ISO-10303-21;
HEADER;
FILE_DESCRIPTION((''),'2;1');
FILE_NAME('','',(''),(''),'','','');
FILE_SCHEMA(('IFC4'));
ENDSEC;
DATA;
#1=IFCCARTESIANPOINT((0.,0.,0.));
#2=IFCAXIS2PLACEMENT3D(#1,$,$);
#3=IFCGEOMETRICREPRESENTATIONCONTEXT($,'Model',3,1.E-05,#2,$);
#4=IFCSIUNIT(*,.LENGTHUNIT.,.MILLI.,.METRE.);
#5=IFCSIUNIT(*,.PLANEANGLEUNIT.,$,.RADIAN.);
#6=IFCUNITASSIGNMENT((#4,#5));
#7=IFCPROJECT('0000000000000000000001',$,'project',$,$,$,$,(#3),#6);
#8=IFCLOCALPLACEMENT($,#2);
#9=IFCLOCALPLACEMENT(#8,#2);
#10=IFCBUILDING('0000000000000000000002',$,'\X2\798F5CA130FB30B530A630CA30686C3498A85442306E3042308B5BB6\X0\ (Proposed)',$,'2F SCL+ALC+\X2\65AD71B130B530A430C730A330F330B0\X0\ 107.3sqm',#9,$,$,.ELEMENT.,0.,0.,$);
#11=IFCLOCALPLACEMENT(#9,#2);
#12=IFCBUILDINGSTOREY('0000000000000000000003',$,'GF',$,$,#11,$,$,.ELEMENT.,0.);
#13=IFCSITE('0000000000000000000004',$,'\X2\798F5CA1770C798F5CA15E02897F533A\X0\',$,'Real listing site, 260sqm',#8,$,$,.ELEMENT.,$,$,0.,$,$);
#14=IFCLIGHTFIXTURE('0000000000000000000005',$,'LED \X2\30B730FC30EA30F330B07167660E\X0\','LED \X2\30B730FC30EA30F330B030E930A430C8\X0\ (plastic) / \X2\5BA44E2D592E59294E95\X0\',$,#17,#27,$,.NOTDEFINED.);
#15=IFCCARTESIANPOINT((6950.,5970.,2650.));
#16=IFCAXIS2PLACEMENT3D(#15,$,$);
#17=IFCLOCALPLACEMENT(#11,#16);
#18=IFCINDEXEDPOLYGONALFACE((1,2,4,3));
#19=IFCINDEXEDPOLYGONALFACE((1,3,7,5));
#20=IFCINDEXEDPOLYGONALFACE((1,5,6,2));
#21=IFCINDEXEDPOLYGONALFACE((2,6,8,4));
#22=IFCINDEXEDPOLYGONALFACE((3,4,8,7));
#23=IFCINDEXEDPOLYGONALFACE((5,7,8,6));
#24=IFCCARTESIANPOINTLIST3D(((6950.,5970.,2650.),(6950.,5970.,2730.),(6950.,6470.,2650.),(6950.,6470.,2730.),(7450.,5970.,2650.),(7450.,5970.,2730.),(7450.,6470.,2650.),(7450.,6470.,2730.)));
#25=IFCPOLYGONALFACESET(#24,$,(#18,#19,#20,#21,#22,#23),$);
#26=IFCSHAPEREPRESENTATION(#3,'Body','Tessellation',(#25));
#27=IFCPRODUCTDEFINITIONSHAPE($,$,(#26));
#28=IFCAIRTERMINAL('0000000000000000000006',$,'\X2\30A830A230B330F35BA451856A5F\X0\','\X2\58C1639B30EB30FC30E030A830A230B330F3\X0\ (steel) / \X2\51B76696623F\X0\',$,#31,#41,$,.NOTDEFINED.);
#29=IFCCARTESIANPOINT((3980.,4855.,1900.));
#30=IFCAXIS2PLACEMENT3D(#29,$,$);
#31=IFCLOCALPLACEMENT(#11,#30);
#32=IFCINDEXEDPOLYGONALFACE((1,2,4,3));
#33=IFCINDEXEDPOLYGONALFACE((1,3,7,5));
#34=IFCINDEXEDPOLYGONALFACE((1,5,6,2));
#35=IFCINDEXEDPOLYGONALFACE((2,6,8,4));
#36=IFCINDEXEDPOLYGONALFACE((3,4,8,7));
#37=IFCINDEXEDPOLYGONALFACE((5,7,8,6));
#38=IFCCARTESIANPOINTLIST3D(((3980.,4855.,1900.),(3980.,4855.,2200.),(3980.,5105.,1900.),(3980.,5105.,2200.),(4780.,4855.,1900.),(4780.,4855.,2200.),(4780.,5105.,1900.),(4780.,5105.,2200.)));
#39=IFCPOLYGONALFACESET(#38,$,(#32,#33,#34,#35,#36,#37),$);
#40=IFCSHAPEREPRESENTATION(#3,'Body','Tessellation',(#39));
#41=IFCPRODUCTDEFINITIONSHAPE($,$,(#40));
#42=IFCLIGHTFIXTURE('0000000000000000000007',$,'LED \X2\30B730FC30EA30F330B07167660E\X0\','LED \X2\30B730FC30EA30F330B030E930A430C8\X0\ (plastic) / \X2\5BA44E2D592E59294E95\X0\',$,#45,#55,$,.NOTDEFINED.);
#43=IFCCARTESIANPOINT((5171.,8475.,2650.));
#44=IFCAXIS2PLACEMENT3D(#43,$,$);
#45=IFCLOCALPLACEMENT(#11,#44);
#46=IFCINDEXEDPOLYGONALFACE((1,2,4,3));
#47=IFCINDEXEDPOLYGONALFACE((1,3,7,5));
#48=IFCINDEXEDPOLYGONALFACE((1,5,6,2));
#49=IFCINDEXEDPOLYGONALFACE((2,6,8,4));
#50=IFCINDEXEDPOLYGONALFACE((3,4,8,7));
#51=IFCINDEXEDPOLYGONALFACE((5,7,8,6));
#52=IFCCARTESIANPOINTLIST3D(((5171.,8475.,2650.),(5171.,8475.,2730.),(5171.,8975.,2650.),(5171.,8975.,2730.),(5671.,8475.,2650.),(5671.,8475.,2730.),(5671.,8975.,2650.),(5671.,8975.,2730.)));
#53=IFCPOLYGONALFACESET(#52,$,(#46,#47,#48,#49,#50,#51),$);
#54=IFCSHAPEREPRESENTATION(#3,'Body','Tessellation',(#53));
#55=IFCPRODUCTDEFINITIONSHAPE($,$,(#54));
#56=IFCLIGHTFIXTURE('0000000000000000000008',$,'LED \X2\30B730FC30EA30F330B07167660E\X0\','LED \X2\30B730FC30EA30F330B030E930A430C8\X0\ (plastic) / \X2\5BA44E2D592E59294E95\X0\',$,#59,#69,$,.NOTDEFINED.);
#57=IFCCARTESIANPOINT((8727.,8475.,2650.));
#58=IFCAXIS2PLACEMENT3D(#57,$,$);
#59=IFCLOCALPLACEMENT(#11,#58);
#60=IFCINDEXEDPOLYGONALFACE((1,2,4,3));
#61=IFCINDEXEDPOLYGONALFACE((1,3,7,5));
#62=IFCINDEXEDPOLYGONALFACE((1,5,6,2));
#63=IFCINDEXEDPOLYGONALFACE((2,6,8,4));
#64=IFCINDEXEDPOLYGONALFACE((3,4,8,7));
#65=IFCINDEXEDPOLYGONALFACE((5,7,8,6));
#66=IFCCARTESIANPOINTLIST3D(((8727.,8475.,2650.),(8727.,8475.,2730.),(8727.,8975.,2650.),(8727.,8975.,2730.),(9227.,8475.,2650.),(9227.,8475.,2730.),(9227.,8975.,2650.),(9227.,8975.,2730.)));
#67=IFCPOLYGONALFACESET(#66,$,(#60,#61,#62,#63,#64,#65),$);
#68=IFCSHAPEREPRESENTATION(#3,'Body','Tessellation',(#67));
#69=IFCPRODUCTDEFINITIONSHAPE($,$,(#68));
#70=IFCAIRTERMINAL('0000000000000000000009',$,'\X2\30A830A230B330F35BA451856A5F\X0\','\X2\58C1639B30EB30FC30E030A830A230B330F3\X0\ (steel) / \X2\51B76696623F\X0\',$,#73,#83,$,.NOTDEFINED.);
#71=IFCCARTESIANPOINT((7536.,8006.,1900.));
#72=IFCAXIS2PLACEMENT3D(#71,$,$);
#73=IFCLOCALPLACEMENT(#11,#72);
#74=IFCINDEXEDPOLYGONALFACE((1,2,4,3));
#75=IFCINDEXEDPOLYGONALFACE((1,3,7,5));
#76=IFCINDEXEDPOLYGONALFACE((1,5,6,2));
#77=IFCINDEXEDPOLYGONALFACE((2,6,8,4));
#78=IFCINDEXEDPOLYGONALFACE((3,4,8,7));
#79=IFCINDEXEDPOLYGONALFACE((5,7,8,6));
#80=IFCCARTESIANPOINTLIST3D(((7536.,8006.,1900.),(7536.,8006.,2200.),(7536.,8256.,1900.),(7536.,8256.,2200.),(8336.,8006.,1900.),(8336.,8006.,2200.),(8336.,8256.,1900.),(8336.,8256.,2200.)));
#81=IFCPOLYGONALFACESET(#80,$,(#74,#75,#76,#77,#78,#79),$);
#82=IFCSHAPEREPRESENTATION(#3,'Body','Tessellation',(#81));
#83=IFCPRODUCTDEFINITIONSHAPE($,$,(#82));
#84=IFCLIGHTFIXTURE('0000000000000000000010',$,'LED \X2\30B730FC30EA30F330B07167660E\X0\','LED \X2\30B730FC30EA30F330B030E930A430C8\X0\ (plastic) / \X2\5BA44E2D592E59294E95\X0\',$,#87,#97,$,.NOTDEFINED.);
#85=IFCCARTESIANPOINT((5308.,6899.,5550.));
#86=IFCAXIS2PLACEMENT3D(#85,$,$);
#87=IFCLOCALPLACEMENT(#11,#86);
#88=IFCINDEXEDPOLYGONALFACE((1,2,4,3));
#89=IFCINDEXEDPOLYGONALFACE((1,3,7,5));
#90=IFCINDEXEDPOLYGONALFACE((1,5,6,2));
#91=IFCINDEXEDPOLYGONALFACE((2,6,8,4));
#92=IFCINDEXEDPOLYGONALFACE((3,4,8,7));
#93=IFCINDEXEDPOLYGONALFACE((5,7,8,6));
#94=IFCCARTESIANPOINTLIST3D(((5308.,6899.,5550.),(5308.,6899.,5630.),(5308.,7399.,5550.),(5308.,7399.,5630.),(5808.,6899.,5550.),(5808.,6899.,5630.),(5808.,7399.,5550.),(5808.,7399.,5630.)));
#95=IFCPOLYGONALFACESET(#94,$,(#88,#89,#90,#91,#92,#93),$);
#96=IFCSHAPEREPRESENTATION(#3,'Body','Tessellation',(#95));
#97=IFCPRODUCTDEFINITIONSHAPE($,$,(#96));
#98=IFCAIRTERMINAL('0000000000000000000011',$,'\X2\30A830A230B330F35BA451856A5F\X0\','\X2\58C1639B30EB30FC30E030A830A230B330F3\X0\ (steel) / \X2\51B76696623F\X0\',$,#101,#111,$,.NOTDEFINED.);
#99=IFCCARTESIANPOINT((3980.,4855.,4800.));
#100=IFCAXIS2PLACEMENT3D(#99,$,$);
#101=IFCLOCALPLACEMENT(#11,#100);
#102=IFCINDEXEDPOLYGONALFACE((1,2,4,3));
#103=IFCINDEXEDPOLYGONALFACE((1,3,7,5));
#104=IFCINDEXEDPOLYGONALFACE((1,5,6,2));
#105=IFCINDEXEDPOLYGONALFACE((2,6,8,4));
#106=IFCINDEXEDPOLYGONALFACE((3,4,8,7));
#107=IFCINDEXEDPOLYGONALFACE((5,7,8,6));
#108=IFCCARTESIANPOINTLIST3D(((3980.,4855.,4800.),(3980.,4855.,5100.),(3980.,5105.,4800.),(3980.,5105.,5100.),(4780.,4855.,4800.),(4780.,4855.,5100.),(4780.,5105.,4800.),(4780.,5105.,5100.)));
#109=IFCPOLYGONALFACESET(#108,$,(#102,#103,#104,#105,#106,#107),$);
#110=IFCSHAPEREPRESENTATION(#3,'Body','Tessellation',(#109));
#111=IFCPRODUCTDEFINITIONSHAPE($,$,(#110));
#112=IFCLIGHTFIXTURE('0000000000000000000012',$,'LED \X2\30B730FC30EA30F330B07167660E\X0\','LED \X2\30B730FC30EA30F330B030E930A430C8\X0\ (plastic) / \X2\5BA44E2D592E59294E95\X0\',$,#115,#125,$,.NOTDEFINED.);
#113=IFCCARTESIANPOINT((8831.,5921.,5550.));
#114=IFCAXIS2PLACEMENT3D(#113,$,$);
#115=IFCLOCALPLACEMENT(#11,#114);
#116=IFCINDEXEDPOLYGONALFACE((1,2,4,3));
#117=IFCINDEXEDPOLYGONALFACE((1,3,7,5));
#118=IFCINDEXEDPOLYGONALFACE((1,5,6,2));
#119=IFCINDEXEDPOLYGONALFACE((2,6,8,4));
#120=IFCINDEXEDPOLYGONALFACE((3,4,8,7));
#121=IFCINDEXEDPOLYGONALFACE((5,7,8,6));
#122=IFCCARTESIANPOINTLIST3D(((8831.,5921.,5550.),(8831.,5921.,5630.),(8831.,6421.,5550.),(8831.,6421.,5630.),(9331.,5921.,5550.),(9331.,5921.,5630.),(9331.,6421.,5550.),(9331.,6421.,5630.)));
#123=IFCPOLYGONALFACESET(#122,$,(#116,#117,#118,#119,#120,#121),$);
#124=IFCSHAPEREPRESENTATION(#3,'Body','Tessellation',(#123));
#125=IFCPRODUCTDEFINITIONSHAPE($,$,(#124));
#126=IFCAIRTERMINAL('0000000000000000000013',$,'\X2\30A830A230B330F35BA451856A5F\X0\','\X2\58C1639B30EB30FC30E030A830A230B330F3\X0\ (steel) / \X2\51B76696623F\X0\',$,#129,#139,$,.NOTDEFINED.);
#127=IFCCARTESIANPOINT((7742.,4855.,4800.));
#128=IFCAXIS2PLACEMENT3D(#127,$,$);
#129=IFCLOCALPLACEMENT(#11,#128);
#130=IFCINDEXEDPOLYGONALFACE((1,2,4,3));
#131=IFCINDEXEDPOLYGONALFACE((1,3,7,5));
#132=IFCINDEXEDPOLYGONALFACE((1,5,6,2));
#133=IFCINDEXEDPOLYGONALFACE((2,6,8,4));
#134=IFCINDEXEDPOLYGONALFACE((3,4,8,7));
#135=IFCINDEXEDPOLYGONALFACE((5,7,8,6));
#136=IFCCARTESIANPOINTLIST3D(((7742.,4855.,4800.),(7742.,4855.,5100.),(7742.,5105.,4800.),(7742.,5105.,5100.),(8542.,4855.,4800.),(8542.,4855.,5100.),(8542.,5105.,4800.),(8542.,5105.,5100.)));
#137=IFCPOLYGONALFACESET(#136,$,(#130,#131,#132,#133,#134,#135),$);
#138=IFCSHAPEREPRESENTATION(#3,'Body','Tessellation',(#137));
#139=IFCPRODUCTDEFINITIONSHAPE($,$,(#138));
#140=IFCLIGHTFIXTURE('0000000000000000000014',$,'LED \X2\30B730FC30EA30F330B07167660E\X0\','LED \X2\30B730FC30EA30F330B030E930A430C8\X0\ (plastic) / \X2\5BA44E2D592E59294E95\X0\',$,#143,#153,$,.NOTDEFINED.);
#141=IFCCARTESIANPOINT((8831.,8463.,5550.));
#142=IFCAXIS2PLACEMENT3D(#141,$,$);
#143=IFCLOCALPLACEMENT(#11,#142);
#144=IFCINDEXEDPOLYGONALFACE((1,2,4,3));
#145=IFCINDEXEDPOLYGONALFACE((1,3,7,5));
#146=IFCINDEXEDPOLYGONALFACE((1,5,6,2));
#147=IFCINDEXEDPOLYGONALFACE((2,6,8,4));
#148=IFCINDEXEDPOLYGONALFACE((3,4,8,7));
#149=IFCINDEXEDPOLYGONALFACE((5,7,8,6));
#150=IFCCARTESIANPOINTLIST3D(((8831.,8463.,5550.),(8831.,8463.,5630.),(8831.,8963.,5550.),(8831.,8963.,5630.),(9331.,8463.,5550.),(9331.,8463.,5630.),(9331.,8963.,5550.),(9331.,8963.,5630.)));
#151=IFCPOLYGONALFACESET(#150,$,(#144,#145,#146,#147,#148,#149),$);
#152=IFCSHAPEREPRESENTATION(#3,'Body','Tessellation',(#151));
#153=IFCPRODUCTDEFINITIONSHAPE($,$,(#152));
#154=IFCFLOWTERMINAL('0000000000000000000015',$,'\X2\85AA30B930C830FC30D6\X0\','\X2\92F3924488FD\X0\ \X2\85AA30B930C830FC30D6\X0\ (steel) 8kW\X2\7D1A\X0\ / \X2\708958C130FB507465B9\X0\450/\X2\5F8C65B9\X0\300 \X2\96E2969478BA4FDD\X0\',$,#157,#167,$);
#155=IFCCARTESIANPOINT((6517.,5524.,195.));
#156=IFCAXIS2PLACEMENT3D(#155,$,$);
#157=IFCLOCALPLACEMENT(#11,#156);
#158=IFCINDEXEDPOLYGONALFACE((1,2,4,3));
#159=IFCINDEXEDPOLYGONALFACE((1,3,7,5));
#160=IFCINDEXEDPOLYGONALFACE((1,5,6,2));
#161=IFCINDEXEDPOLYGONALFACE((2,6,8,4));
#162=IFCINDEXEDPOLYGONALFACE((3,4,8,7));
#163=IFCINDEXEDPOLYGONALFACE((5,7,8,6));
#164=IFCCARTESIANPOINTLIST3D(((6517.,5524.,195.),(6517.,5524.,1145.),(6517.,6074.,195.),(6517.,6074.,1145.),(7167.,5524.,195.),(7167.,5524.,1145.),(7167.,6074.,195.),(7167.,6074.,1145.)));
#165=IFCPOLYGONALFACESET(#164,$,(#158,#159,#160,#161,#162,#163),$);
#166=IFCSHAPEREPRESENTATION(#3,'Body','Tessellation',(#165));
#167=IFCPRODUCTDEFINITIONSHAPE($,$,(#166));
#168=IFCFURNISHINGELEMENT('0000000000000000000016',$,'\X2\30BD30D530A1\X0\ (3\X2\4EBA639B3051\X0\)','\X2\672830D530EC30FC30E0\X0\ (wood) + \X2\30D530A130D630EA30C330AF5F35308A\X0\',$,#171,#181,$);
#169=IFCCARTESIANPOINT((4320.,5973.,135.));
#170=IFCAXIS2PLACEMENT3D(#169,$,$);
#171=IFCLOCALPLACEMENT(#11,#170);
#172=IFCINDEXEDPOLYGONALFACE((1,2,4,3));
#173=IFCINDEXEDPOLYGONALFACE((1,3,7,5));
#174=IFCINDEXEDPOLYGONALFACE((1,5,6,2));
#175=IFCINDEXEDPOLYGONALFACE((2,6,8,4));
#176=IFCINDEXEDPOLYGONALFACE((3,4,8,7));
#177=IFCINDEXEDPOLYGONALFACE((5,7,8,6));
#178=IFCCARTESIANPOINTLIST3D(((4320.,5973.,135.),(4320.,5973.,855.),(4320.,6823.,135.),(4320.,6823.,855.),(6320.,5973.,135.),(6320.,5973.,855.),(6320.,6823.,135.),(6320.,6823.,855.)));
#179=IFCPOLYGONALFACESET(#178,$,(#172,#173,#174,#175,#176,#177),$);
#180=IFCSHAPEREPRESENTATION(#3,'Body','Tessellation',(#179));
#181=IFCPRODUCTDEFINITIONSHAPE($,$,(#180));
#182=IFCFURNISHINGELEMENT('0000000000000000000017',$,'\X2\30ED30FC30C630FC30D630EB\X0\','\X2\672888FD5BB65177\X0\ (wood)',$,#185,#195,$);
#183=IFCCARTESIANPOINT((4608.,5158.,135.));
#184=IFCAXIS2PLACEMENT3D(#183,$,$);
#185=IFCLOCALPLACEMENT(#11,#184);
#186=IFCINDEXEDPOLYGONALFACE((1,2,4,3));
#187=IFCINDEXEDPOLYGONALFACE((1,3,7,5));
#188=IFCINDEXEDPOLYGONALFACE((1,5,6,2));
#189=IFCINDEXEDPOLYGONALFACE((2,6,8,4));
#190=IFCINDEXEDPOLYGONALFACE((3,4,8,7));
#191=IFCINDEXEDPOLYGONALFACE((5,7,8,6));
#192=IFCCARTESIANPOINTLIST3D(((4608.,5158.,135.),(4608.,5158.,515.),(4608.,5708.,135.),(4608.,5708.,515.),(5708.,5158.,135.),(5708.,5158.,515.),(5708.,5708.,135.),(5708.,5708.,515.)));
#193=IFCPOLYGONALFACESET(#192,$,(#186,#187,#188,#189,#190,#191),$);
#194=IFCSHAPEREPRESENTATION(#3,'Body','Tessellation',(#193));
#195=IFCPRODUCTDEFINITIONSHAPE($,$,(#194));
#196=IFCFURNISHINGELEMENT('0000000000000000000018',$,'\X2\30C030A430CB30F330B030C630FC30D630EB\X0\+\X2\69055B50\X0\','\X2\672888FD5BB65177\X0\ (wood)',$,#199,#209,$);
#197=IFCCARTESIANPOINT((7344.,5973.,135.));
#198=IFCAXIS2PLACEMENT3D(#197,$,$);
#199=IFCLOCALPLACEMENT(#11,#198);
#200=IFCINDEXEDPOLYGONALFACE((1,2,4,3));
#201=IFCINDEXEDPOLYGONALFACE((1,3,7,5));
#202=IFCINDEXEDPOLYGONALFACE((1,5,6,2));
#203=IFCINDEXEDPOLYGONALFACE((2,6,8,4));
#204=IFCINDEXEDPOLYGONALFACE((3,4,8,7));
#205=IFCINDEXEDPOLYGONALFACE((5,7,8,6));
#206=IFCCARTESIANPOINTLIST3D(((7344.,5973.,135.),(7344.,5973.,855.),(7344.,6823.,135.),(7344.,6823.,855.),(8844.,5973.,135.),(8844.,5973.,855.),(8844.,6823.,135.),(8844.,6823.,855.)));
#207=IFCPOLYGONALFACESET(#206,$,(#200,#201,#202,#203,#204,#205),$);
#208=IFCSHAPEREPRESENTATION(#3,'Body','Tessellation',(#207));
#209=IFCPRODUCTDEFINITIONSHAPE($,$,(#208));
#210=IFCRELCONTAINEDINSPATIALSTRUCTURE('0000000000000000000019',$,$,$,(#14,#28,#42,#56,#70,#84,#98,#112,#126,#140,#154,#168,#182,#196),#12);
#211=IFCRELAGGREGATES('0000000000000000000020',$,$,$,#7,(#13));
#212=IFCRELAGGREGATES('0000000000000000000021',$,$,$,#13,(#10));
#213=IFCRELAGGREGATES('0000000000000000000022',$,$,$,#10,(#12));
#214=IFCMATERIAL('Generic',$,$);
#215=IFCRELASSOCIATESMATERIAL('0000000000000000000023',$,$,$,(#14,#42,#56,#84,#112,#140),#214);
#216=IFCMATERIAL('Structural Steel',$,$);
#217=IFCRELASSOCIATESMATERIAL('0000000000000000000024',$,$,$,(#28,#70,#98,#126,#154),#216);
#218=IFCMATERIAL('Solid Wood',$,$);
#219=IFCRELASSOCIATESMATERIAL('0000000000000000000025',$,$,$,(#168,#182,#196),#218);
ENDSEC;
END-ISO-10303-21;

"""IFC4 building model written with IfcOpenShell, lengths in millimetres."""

from ifc_helpers import new_model, si_unit, frame, frame_2d, origin, place, context, project, spatial, rectangle, extrude, material, element, save


model = new_model("IFC4")

# Units and contexts
model_context = context("Model", 3, precision=1e-05, world=origin())
ifc_project = project(units=[si_unit("LENGTHUNIT", "METRE", prefix="MILLI"), si_unit("PLANEANGLEUNIT", "RADIAN")], contexts=[model_context])

# Site, building, storey
site_placement = place(None, origin())
site = spatial("IfcSite", under=ifc_project, at=site_placement, Name="福岡県福岡市西区", ObjectType="Real listing site, 260sqm", CompositionType="ELEMENT", RefElevation=0.0)
building_placement = place(site_placement, origin())
building = spatial("IfcBuilding", under=site, at=building_placement, Name="福岡・サウナと水風呂のある家 (Proposed)", ObjectType="2F SCL+ALC+断熱サイディング 107.3sqm", CompositionType="ELEMENT", ElevationOfRefHeight=0.0, ElevationOfTerrain=0.0)
storey_placement = place(building_placement, origin())
storey = spatial("IfcBuildingStorey", under=building, at=storey_placement, Name="GF", CompositionType="ELEMENT", Elevation=0.0)

# Shared definitions
ifc_material_1 = material(Name="Solid Wood")

# Shared definitions
ifc_material_2 = material(Name="Structural Steel")

# Shared definitions
ifc_material_3 = material(Name="Generic")

# Light fixture
light_fixture_1_placement = place(storey_placement, frame((6950.0, 5970.0, 2650.0)))
element("IfcLightFixture", 1, at=light_fixture_1_placement, inside=storey, material=ifc_material_3, Name="LED シーリング照明", Description="LED シーリングライト (plastic) / 室中央天井", PredefinedType="NOTDEFINED", context=model_context, shape_type="SweptSolid", body=[
    extrude(rectangle(XDim=500.0, YDim=500.0, at=frame_2d((250.0, 250.0))), frame((6950.0, 5970.0, 2650.0)), (0.0, 0.0, 1.0), 80.0),
])

# Air terminal
air_terminal_1_placement = place(storey_placement, frame((3980.0, 4855.0, 1900.0)))
element("IfcAirTerminal", 2, at=air_terminal_1_placement, inside=storey, material=ifc_material_2, Name="エアコン室内機", Description="壁掛ルームエアコン (steel) / 冷暖房", PredefinedType="NOTDEFINED", context=model_context, shape_type="SweptSolid", body=[
    extrude(rectangle(XDim=800.0, YDim=250.0, at=frame_2d((400.0, 125.0))), frame((3980.0, 4855.0, 1900.0)), (0.0, 0.0, 1.0), 300.0),
])

# Light fixtures
light_fixture_2_placement = place(storey_placement, frame((5171.0, 8475.0, 2650.0)))
element("IfcLightFixture", 3, at=light_fixture_2_placement, inside=storey, material=ifc_material_3, Name="LED シーリング照明", Description="LED シーリングライト (plastic) / 室中央天井", PredefinedType="NOTDEFINED", context=model_context, shape_type="SweptSolid", body=[
    extrude(rectangle(XDim=500.0, YDim=500.0, at=frame_2d((250.0, 250.0))), frame((5171.0, 8475.0, 2650.0)), (0.0, 0.0, 1.0), 80.0),
])
light_fixture_3_placement = place(storey_placement, frame((8727.0, 8475.0, 2650.0)))
element("IfcLightFixture", 4, at=light_fixture_3_placement, inside=storey, material=ifc_material_3, Name="LED シーリング照明", Description="LED シーリングライト (plastic) / 室中央天井", PredefinedType="NOTDEFINED", context=model_context, shape_type="SweptSolid", body=[
    extrude(rectangle(XDim=500.0, YDim=500.0, at=frame_2d((250.0, 250.0))), frame((8727.0, 8475.0, 2650.0)), (0.0, 0.0, 1.0), 80.0),
])

# Air terminal
air_terminal_2_placement = place(storey_placement, frame((7536.0, 8006.0, 1900.0)))
element("IfcAirTerminal", 5, at=air_terminal_2_placement, inside=storey, material=ifc_material_2, Name="エアコン室内機", Description="壁掛ルームエアコン (steel) / 冷暖房", PredefinedType="NOTDEFINED", context=model_context, shape_type="SweptSolid", body=[
    extrude(rectangle(XDim=800.0, YDim=250.0, at=frame_2d((400.0, 125.0))), frame((7536.0, 8006.0, 1900.0)), (0.0, 0.0, 1.0), 300.0),
])

# Light fixture
light_fixture_4_placement = place(storey_placement, frame((5308.0, 6899.0, 5550.0)))
element("IfcLightFixture", 6, at=light_fixture_4_placement, inside=storey, material=ifc_material_3, Name="LED シーリング照明", Description="LED シーリングライト (plastic) / 室中央天井", PredefinedType="NOTDEFINED", context=model_context, shape_type="SweptSolid", body=[
    extrude(rectangle(XDim=500.0, YDim=500.0, at=frame_2d((250.0, 250.0))), frame((5308.0, 6899.0, 5550.0)), (0.0, 0.0, 1.0), 80.0),
])

# Air terminal
air_terminal_3_placement = place(storey_placement, frame((3980.0, 4855.0, 4800.0)))
element("IfcAirTerminal", 7, at=air_terminal_3_placement, inside=storey, material=ifc_material_2, Name="エアコン室内機", Description="壁掛ルームエアコン (steel) / 冷暖房", PredefinedType="NOTDEFINED", context=model_context, shape_type="SweptSolid", body=[
    extrude(rectangle(XDim=800.0, YDim=250.0, at=frame_2d((400.0, 125.0))), frame((3980.0, 4855.0, 4800.0)), (0.0, 0.0, 1.0), 300.0),
])

# Light fixture
light_fixture_5_placement = place(storey_placement, frame((8831.0, 5921.0, 5550.0)))
element("IfcLightFixture", 8, at=light_fixture_5_placement, inside=storey, material=ifc_material_3, Name="LED シーリング照明", Description="LED シーリングライト (plastic) / 室中央天井", PredefinedType="NOTDEFINED", context=model_context, shape_type="SweptSolid", body=[
    extrude(rectangle(XDim=500.0, YDim=500.0, at=frame_2d((250.0, 250.0))), frame((8831.0, 5921.0, 5550.0)), (0.0, 0.0, 1.0), 80.0),
])

# Air terminal
air_terminal_4_placement = place(storey_placement, frame((7742.0, 4855.0, 4800.0)))
element("IfcAirTerminal", 9, at=air_terminal_4_placement, inside=storey, material=ifc_material_2, Name="エアコン室内機", Description="壁掛ルームエアコン (steel) / 冷暖房", PredefinedType="NOTDEFINED", context=model_context, shape_type="SweptSolid", body=[
    extrude(rectangle(XDim=800.0, YDim=250.0, at=frame_2d((400.0, 125.0))), frame((7742.0, 4855.0, 4800.0)), (0.0, 0.0, 1.0), 300.0),
])

# Light fixture
light_fixture_6_placement = place(storey_placement, frame((8831.0, 8463.0, 5550.0)))
element("IfcLightFixture", 10, at=light_fixture_6_placement, inside=storey, material=ifc_material_3, Name="LED シーリング照明", Description="LED シーリングライト (plastic) / 室中央天井", PredefinedType="NOTDEFINED", context=model_context, shape_type="SweptSolid", body=[
    extrude(rectangle(XDim=500.0, YDim=500.0, at=frame_2d((250.0, 250.0))), frame((8831.0, 8463.0, 5550.0)), (0.0, 0.0, 1.0), 80.0),
])

# Flow terminal
flow_terminal_1_placement = place(storey_placement, frame((6517.0, 5524.0, 195.0)))
element("IfcFlowTerminal", 11, at=flow_terminal_1_placement, inside=storey, material=ifc_material_2, Name="薪ストーブ", Description="鋳鉄製 薪ストーブ (steel) 8kW級 / 炉壁・側方450/後方300 離隔確保", context=model_context, shape_type="SweptSolid", body=[
    extrude(rectangle(XDim=650.0, YDim=550.0, at=frame_2d((325.0, 275.0))), frame((6517.0, 5524.0, 195.0)), (0.0, 0.0, 1.0), 950.0),
])

# Furnishing elements
furnishing_1_placement = place(storey_placement, frame((4320.0, 5973.0, 135.0)))
element("IfcFurnishingElement", 12, at=furnishing_1_placement, inside=storey, material=ifc_material_1, Name="ソファ (3人掛け)", Description="木フレーム (wood) + ファブリック張り", context=model_context, shape_type="SweptSolid", body=[
    extrude(rectangle(XDim=2000.0, YDim=850.0, at=frame_2d((1000.0, 425.0))), frame((4320.0, 5973.0, 135.0)), (0.0, 0.0, 1.0), 720.0),
])
furnishing_2_placement = place(storey_placement, frame((4608.0, 5158.0, 135.0)))
element("IfcFurnishingElement", 13, at=furnishing_2_placement, inside=storey, material=ifc_material_1, Name="ローテーブル", Description="木製家具 (wood)", context=model_context, shape_type="SweptSolid", body=[
    extrude(rectangle(XDim=1100.0, YDim=550.0, at=frame_2d((550.0, 275.0))), frame((4608.0, 5158.0, 135.0)), (0.0, 0.0, 1.0), 380.0),
])
furnishing_3_placement = place(storey_placement, frame((7344.0, 5973.0, 135.0)))
element("IfcFurnishingElement", 14, at=furnishing_3_placement, inside=storey, material=ifc_material_1, Name="ダイニングテーブル+椅子", Description="木製家具 (wood)", context=model_context, shape_type="SweptSolid", body=[
    extrude(rectangle(XDim=1500.0, YDim=850.0, at=frame_2d((750.0, 425.0))), frame((7344.0, 5973.0, 135.0)), (0.0, 0.0, 1.0), 720.0),
])

save(model, "model.ifc")
